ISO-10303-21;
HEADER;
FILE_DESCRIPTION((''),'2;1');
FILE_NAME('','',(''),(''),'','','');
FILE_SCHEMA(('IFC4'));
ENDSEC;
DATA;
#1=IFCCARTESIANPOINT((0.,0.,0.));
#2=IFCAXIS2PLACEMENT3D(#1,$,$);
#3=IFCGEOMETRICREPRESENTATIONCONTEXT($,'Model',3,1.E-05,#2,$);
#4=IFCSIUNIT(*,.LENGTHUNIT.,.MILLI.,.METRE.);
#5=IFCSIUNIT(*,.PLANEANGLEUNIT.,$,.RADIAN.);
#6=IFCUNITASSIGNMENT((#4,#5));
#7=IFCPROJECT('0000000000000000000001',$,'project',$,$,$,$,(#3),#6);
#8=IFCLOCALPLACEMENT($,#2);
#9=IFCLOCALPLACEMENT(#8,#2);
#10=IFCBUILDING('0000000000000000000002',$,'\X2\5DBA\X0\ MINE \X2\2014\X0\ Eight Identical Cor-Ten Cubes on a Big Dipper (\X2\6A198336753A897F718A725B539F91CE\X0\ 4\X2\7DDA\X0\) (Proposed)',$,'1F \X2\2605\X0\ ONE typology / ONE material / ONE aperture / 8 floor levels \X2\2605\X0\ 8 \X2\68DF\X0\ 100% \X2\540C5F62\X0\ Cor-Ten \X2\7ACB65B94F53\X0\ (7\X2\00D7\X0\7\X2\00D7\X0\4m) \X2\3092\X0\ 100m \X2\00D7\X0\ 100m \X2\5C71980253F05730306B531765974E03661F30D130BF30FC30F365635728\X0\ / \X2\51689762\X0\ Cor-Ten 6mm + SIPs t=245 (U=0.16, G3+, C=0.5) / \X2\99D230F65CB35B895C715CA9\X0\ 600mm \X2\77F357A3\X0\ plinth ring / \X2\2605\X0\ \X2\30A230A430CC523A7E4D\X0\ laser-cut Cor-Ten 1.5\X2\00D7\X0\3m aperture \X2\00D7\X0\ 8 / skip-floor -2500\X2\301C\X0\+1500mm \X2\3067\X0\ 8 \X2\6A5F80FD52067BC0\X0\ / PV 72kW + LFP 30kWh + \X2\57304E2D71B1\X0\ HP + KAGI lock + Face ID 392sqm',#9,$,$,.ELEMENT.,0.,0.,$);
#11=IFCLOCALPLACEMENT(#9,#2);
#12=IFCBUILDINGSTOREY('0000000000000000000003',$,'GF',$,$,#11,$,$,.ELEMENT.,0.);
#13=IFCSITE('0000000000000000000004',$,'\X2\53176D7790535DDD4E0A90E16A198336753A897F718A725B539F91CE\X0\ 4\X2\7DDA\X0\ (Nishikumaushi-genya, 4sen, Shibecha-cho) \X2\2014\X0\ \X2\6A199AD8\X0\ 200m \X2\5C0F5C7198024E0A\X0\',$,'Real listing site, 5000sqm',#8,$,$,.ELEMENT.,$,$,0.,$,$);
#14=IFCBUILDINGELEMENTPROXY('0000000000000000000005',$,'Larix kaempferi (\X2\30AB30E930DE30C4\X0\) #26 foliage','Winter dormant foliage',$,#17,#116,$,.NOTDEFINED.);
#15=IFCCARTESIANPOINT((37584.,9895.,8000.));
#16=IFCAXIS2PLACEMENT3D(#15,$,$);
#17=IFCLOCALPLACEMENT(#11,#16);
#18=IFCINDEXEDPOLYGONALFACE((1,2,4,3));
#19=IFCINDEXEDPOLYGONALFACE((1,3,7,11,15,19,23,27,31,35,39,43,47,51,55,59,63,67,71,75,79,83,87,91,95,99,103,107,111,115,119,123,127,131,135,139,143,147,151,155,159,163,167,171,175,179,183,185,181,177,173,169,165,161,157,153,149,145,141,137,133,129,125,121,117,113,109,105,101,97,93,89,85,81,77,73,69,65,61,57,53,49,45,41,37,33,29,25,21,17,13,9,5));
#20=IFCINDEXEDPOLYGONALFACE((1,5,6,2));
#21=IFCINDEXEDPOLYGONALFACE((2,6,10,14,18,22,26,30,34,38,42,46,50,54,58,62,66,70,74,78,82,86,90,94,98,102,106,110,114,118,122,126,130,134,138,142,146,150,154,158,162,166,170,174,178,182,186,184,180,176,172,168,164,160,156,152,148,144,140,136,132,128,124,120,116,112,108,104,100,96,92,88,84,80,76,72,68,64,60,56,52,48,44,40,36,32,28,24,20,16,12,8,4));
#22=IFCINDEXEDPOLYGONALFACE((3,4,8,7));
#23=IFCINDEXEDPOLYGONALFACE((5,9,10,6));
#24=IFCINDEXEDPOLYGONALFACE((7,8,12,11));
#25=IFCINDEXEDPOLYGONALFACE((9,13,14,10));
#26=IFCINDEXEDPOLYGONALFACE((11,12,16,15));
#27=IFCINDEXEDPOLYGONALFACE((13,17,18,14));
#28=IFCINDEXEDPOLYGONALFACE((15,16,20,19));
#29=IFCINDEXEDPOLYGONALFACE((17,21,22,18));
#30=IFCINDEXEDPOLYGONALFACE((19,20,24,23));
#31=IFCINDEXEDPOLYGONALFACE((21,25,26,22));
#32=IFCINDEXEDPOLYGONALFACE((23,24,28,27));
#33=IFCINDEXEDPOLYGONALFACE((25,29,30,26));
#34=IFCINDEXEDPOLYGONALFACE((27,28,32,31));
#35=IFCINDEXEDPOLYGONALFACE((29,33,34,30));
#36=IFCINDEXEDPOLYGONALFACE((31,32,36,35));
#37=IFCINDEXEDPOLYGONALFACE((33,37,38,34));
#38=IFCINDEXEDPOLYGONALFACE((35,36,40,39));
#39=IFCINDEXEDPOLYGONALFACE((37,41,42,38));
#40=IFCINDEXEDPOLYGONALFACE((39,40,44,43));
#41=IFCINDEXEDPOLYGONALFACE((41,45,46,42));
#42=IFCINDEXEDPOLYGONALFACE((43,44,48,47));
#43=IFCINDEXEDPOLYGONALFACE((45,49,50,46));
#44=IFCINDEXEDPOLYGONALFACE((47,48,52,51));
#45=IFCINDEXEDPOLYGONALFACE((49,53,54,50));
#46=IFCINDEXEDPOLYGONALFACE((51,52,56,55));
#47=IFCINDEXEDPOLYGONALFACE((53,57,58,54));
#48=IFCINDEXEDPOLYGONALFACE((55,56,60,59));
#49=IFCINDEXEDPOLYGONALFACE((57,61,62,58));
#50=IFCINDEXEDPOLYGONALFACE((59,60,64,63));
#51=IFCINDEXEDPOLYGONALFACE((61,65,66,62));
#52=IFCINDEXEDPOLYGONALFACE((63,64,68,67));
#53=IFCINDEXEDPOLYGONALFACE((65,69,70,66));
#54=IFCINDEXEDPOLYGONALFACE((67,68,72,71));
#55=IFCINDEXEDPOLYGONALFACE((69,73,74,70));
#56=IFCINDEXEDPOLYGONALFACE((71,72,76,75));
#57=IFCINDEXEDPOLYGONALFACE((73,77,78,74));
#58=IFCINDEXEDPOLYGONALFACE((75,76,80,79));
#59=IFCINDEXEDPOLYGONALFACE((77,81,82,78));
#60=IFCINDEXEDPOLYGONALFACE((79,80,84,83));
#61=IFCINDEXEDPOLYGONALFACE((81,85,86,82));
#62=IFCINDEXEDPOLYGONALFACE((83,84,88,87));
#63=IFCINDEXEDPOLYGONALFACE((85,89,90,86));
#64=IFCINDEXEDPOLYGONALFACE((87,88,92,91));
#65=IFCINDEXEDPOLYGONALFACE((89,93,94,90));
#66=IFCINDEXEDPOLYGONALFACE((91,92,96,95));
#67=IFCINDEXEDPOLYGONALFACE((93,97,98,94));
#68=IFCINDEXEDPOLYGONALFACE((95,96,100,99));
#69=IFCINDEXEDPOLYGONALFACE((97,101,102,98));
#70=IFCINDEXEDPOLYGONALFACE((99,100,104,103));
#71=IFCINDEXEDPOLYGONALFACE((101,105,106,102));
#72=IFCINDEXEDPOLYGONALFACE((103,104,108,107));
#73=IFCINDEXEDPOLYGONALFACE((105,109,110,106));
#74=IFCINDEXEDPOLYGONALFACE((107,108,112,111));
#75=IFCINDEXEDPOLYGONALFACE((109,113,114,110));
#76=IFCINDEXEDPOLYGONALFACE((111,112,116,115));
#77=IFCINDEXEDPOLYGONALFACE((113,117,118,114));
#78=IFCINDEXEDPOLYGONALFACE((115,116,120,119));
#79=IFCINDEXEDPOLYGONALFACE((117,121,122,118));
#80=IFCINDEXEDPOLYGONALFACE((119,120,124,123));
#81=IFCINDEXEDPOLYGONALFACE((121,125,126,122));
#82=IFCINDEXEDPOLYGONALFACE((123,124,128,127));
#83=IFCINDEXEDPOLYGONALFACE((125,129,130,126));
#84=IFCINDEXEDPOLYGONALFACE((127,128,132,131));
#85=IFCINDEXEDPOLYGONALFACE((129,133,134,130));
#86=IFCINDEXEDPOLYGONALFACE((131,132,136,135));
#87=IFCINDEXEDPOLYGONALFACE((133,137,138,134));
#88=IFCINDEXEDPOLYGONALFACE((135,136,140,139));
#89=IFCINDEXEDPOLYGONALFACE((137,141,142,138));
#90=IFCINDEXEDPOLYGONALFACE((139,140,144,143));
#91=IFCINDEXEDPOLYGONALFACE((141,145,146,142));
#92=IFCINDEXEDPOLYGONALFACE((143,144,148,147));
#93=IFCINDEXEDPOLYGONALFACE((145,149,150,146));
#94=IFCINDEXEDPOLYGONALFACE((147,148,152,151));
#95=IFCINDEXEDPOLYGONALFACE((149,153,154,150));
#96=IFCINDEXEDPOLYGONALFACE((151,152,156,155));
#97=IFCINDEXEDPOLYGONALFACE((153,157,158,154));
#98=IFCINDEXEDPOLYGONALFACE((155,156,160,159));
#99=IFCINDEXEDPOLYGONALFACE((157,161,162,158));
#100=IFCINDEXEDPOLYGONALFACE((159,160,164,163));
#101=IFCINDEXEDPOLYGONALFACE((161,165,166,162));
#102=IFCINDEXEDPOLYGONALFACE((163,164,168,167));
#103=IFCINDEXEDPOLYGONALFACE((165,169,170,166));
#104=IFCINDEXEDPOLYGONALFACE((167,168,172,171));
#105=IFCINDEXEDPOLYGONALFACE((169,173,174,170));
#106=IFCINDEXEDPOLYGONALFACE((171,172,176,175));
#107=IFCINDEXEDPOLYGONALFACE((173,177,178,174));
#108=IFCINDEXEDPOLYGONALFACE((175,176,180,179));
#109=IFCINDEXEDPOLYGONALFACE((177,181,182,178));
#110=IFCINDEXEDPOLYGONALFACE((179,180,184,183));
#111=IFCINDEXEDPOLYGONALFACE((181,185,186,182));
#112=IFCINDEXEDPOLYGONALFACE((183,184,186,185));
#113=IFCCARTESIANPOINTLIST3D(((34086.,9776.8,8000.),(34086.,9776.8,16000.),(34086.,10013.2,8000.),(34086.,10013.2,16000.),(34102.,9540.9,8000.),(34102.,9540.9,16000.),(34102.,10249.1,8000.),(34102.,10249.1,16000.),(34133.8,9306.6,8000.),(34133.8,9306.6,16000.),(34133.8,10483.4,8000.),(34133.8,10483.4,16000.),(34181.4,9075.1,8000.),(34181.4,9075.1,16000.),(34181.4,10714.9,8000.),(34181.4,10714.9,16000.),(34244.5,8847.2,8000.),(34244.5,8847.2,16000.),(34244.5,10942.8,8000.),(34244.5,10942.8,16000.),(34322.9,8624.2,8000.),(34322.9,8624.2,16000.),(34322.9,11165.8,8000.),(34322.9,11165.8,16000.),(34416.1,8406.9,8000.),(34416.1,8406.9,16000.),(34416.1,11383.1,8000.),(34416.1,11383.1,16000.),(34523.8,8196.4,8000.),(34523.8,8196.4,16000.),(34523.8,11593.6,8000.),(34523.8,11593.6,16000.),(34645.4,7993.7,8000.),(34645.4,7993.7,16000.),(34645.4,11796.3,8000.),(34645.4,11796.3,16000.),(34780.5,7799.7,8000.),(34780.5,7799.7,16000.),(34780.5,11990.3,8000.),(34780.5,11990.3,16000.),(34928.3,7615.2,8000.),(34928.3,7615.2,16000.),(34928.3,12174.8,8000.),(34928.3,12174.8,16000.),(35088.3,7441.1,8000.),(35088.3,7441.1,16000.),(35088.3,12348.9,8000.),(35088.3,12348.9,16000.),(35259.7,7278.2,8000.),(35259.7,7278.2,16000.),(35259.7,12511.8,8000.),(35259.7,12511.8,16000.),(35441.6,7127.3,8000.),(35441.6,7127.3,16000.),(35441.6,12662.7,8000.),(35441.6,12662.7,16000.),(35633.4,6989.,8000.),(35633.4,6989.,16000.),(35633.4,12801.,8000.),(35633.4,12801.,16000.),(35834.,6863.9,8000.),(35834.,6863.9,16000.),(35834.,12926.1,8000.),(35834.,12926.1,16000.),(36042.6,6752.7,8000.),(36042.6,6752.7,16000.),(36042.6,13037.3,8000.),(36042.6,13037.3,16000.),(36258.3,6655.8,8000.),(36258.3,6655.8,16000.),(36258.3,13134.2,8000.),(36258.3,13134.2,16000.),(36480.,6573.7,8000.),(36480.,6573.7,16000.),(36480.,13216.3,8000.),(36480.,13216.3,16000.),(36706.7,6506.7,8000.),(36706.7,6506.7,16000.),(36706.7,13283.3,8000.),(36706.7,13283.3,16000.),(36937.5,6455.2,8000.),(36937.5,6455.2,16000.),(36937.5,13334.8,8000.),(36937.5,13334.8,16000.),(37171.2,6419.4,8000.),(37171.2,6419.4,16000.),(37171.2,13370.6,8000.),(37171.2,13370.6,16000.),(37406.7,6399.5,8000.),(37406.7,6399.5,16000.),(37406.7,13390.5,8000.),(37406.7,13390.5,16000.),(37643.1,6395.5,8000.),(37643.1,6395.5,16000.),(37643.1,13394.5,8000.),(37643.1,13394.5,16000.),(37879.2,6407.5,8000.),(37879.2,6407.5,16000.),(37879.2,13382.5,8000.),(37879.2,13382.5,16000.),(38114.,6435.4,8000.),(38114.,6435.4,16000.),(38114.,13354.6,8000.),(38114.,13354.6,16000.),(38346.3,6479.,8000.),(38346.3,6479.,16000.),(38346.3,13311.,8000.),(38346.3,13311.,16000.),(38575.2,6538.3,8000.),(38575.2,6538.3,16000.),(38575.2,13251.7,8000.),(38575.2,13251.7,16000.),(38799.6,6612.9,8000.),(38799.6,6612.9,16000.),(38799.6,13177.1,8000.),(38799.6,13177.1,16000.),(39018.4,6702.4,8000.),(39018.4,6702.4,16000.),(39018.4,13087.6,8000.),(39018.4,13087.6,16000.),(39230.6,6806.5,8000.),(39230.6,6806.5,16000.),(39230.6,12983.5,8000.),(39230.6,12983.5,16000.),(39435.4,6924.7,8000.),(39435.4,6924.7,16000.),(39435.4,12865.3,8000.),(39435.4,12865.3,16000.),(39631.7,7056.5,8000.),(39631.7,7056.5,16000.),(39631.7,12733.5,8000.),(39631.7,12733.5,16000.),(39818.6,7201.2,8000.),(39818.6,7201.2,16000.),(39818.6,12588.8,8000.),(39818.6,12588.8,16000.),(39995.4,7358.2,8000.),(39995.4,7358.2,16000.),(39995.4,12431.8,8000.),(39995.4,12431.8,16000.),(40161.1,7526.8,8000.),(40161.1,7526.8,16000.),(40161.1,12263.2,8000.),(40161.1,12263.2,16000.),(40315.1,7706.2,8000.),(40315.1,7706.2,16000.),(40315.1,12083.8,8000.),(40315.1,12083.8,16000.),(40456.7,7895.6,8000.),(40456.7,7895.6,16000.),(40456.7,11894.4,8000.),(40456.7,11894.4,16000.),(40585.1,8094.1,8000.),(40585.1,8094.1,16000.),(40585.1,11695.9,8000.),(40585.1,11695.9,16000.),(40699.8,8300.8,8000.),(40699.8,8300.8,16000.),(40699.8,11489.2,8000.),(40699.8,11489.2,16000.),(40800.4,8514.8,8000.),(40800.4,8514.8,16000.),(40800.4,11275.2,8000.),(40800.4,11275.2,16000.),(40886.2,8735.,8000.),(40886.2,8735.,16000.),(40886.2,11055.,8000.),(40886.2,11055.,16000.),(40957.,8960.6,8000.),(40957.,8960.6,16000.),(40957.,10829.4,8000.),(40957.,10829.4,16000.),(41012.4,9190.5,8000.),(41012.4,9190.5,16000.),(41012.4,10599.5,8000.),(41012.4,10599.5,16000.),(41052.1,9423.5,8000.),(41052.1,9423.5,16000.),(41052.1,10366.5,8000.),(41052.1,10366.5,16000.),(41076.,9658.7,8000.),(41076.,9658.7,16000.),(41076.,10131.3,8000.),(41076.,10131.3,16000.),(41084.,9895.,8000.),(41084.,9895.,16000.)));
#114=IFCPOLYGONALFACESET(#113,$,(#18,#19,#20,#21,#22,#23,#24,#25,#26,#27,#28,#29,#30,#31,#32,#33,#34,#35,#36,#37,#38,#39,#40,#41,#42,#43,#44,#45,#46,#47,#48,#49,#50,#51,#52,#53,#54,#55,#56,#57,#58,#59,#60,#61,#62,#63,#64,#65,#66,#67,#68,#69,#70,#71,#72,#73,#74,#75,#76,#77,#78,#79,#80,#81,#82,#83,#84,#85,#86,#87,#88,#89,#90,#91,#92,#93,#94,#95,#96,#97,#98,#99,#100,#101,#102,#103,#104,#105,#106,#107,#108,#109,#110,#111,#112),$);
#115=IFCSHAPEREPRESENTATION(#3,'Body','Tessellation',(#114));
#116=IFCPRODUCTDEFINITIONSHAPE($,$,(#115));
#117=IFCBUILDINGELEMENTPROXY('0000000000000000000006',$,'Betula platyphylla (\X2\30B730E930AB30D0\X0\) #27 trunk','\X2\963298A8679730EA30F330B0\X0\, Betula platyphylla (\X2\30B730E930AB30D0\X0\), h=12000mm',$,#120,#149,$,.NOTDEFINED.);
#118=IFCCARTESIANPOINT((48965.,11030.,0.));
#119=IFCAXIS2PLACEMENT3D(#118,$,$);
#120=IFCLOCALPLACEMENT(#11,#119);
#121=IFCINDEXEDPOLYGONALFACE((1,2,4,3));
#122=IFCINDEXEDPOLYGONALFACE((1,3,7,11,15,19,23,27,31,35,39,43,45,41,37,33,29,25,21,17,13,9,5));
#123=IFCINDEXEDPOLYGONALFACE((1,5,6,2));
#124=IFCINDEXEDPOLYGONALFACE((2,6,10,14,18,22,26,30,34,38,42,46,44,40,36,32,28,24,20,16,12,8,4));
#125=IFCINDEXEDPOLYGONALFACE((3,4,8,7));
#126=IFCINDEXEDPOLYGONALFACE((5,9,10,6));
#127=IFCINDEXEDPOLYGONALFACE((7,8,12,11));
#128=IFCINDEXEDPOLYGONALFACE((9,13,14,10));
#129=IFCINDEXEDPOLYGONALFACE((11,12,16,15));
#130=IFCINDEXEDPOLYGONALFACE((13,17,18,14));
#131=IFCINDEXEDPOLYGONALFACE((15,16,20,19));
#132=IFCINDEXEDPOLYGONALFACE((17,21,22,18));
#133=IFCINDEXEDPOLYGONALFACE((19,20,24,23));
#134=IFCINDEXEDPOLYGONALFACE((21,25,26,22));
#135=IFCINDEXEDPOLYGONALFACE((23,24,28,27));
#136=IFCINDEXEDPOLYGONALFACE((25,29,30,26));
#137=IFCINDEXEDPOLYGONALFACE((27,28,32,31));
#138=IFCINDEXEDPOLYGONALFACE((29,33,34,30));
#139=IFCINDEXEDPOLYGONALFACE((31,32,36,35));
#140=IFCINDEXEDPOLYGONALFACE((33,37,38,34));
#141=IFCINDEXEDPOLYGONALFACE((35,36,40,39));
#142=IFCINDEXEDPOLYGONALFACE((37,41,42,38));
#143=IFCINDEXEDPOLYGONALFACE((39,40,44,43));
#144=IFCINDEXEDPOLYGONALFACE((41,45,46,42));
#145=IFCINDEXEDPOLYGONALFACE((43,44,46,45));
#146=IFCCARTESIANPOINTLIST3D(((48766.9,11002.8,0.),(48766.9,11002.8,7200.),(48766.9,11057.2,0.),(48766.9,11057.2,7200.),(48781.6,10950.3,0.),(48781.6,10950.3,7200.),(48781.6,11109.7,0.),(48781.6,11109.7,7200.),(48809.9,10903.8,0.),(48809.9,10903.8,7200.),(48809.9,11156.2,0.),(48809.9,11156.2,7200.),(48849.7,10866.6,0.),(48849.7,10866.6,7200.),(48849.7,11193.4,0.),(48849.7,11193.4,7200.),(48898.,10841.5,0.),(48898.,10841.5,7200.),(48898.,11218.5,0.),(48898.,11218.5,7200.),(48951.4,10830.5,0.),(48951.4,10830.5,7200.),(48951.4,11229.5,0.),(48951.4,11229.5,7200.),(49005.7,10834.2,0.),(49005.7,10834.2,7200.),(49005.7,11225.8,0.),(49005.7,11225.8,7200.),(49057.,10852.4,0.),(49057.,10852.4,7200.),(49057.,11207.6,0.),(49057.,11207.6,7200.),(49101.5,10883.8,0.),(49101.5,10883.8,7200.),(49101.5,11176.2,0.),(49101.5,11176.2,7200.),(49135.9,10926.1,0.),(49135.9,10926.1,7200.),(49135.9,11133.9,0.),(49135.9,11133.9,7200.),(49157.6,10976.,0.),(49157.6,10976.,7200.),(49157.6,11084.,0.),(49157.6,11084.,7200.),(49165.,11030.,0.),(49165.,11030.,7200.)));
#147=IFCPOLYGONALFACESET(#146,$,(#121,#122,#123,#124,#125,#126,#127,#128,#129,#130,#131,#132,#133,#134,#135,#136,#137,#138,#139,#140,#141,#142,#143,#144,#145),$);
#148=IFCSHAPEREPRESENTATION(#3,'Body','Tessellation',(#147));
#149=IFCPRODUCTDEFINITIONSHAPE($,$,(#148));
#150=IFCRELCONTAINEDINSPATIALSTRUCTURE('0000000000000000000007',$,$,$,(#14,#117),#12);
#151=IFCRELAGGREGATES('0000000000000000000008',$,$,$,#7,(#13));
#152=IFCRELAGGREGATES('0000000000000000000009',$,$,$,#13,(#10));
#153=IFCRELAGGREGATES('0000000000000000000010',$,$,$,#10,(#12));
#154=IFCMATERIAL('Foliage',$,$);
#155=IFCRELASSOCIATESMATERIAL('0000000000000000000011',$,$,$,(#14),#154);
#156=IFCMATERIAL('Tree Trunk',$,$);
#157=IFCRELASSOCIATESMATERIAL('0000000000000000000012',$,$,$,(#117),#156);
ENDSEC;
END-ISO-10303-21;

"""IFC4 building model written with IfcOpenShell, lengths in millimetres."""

from ifc_helpers import new_model, si_unit, frame, origin, origin_2d, place, context, project, spatial, circle, extrude, material, element, save


model = new_model("IFC4")

# Units and contexts
model_context = context("Model", 3, precision=1e-05, world=origin())
ifc_project = project(units=[si_unit("LENGTHUNIT", "METRE", prefix="MILLI"), si_unit("PLANEANGLEUNIT", "RADIAN")], contexts=[model_context])

# Site, building, storey
site_placement = place(None, origin())
site = spatial("IfcSite", under=ifc_project, at=site_placement, Name="北海道川上郡標茶町西熊牛原野 4線 (Nishikumaushi-genya, 4sen, Shibecha-cho) — 標高 200m 小山頂上", ObjectType="Real listing site, 5000sqm", CompositionType="ELEMENT", RefElevation=0.0)
building_placement = place(site_placement, origin())
building = spatial("IfcBuilding", under=site, at=building_placement, Name="嶺 MINE — Eight Identical Cor-Ten Cubes on a Big Dipper (標茶町西熊牛原野 4線) (Proposed)", ObjectType="1F ★ ONE typology / ONE material / ONE aperture / 8 floor levels ★ 8 棟 100% 同形 Cor-Ten 立方体 (7×7×4m) を 100m × 100m 山頂台地に北斗七星パターン散在 / 全面 Cor-Ten 6mm + SIPs t=245 (U=0.16, G3+, C=0.5) / 駒ヶ岳安山岩 600mm 石垣 plinth ring / ★ アイヌ刺繍 laser-cut Cor-Ten 1.5×3m aperture × 8 / skip-floor -2500〜+1500mm で 8 機能分節 / PV 72kW + LFP 30kWh + 地中熱 HP + KAGI lock + Face ID 392sqm", CompositionType="ELEMENT", ElevationOfRefHeight=0.0, ElevationOfTerrain=0.0)
storey_placement = place(building_placement, origin())
storey = spatial("IfcBuildingStorey", under=building, at=storey_placement, Name="GF", CompositionType="ELEMENT", Elevation=0.0)

# Building element proxies
ifc_material_1 = material(Name="Tree Trunk")
ifc_material_2 = material(Name="Foliage")
proxy_1_placement = place(storey_placement, frame((37584.0, 9895.0, 8000.0)))
element("IfcBuildingElementProxy", 1, at=proxy_1_placement, inside=storey, material=ifc_material_2, Name="Larix kaempferi (カラマツ) #26 foliage", Description="Winter dormant foliage", PredefinedType="NOTDEFINED", context=model_context, shape_type="SweptSolid", body=[
    extrude(circle(Radius=3500.0, at=origin_2d()), frame((37584.0, 9895.0, 8000.0)), (0.0, 0.0, 1.0), 8000.0),
])
proxy_2_placement = place(storey_placement, frame((48965.0, 11030.0, 0.0)))
element("IfcBuildingElementProxy", 2, at=proxy_2_placement, inside=storey, material=ifc_material_1, Name="Betula platyphylla (シラカバ) #27 trunk", Description="防風林リング, Betula platyphylla (シラカバ), h=12000mm", PredefinedType="NOTDEFINED", context=model_context, shape_type="SweptSolid", body=[
    extrude(circle(Radius=200.0, at=origin_2d()), frame((48965.0, 11030.0, 0.0)), (0.0, 0.0, 1.0), 7200.0),
])

save(model, "model.ifc")
